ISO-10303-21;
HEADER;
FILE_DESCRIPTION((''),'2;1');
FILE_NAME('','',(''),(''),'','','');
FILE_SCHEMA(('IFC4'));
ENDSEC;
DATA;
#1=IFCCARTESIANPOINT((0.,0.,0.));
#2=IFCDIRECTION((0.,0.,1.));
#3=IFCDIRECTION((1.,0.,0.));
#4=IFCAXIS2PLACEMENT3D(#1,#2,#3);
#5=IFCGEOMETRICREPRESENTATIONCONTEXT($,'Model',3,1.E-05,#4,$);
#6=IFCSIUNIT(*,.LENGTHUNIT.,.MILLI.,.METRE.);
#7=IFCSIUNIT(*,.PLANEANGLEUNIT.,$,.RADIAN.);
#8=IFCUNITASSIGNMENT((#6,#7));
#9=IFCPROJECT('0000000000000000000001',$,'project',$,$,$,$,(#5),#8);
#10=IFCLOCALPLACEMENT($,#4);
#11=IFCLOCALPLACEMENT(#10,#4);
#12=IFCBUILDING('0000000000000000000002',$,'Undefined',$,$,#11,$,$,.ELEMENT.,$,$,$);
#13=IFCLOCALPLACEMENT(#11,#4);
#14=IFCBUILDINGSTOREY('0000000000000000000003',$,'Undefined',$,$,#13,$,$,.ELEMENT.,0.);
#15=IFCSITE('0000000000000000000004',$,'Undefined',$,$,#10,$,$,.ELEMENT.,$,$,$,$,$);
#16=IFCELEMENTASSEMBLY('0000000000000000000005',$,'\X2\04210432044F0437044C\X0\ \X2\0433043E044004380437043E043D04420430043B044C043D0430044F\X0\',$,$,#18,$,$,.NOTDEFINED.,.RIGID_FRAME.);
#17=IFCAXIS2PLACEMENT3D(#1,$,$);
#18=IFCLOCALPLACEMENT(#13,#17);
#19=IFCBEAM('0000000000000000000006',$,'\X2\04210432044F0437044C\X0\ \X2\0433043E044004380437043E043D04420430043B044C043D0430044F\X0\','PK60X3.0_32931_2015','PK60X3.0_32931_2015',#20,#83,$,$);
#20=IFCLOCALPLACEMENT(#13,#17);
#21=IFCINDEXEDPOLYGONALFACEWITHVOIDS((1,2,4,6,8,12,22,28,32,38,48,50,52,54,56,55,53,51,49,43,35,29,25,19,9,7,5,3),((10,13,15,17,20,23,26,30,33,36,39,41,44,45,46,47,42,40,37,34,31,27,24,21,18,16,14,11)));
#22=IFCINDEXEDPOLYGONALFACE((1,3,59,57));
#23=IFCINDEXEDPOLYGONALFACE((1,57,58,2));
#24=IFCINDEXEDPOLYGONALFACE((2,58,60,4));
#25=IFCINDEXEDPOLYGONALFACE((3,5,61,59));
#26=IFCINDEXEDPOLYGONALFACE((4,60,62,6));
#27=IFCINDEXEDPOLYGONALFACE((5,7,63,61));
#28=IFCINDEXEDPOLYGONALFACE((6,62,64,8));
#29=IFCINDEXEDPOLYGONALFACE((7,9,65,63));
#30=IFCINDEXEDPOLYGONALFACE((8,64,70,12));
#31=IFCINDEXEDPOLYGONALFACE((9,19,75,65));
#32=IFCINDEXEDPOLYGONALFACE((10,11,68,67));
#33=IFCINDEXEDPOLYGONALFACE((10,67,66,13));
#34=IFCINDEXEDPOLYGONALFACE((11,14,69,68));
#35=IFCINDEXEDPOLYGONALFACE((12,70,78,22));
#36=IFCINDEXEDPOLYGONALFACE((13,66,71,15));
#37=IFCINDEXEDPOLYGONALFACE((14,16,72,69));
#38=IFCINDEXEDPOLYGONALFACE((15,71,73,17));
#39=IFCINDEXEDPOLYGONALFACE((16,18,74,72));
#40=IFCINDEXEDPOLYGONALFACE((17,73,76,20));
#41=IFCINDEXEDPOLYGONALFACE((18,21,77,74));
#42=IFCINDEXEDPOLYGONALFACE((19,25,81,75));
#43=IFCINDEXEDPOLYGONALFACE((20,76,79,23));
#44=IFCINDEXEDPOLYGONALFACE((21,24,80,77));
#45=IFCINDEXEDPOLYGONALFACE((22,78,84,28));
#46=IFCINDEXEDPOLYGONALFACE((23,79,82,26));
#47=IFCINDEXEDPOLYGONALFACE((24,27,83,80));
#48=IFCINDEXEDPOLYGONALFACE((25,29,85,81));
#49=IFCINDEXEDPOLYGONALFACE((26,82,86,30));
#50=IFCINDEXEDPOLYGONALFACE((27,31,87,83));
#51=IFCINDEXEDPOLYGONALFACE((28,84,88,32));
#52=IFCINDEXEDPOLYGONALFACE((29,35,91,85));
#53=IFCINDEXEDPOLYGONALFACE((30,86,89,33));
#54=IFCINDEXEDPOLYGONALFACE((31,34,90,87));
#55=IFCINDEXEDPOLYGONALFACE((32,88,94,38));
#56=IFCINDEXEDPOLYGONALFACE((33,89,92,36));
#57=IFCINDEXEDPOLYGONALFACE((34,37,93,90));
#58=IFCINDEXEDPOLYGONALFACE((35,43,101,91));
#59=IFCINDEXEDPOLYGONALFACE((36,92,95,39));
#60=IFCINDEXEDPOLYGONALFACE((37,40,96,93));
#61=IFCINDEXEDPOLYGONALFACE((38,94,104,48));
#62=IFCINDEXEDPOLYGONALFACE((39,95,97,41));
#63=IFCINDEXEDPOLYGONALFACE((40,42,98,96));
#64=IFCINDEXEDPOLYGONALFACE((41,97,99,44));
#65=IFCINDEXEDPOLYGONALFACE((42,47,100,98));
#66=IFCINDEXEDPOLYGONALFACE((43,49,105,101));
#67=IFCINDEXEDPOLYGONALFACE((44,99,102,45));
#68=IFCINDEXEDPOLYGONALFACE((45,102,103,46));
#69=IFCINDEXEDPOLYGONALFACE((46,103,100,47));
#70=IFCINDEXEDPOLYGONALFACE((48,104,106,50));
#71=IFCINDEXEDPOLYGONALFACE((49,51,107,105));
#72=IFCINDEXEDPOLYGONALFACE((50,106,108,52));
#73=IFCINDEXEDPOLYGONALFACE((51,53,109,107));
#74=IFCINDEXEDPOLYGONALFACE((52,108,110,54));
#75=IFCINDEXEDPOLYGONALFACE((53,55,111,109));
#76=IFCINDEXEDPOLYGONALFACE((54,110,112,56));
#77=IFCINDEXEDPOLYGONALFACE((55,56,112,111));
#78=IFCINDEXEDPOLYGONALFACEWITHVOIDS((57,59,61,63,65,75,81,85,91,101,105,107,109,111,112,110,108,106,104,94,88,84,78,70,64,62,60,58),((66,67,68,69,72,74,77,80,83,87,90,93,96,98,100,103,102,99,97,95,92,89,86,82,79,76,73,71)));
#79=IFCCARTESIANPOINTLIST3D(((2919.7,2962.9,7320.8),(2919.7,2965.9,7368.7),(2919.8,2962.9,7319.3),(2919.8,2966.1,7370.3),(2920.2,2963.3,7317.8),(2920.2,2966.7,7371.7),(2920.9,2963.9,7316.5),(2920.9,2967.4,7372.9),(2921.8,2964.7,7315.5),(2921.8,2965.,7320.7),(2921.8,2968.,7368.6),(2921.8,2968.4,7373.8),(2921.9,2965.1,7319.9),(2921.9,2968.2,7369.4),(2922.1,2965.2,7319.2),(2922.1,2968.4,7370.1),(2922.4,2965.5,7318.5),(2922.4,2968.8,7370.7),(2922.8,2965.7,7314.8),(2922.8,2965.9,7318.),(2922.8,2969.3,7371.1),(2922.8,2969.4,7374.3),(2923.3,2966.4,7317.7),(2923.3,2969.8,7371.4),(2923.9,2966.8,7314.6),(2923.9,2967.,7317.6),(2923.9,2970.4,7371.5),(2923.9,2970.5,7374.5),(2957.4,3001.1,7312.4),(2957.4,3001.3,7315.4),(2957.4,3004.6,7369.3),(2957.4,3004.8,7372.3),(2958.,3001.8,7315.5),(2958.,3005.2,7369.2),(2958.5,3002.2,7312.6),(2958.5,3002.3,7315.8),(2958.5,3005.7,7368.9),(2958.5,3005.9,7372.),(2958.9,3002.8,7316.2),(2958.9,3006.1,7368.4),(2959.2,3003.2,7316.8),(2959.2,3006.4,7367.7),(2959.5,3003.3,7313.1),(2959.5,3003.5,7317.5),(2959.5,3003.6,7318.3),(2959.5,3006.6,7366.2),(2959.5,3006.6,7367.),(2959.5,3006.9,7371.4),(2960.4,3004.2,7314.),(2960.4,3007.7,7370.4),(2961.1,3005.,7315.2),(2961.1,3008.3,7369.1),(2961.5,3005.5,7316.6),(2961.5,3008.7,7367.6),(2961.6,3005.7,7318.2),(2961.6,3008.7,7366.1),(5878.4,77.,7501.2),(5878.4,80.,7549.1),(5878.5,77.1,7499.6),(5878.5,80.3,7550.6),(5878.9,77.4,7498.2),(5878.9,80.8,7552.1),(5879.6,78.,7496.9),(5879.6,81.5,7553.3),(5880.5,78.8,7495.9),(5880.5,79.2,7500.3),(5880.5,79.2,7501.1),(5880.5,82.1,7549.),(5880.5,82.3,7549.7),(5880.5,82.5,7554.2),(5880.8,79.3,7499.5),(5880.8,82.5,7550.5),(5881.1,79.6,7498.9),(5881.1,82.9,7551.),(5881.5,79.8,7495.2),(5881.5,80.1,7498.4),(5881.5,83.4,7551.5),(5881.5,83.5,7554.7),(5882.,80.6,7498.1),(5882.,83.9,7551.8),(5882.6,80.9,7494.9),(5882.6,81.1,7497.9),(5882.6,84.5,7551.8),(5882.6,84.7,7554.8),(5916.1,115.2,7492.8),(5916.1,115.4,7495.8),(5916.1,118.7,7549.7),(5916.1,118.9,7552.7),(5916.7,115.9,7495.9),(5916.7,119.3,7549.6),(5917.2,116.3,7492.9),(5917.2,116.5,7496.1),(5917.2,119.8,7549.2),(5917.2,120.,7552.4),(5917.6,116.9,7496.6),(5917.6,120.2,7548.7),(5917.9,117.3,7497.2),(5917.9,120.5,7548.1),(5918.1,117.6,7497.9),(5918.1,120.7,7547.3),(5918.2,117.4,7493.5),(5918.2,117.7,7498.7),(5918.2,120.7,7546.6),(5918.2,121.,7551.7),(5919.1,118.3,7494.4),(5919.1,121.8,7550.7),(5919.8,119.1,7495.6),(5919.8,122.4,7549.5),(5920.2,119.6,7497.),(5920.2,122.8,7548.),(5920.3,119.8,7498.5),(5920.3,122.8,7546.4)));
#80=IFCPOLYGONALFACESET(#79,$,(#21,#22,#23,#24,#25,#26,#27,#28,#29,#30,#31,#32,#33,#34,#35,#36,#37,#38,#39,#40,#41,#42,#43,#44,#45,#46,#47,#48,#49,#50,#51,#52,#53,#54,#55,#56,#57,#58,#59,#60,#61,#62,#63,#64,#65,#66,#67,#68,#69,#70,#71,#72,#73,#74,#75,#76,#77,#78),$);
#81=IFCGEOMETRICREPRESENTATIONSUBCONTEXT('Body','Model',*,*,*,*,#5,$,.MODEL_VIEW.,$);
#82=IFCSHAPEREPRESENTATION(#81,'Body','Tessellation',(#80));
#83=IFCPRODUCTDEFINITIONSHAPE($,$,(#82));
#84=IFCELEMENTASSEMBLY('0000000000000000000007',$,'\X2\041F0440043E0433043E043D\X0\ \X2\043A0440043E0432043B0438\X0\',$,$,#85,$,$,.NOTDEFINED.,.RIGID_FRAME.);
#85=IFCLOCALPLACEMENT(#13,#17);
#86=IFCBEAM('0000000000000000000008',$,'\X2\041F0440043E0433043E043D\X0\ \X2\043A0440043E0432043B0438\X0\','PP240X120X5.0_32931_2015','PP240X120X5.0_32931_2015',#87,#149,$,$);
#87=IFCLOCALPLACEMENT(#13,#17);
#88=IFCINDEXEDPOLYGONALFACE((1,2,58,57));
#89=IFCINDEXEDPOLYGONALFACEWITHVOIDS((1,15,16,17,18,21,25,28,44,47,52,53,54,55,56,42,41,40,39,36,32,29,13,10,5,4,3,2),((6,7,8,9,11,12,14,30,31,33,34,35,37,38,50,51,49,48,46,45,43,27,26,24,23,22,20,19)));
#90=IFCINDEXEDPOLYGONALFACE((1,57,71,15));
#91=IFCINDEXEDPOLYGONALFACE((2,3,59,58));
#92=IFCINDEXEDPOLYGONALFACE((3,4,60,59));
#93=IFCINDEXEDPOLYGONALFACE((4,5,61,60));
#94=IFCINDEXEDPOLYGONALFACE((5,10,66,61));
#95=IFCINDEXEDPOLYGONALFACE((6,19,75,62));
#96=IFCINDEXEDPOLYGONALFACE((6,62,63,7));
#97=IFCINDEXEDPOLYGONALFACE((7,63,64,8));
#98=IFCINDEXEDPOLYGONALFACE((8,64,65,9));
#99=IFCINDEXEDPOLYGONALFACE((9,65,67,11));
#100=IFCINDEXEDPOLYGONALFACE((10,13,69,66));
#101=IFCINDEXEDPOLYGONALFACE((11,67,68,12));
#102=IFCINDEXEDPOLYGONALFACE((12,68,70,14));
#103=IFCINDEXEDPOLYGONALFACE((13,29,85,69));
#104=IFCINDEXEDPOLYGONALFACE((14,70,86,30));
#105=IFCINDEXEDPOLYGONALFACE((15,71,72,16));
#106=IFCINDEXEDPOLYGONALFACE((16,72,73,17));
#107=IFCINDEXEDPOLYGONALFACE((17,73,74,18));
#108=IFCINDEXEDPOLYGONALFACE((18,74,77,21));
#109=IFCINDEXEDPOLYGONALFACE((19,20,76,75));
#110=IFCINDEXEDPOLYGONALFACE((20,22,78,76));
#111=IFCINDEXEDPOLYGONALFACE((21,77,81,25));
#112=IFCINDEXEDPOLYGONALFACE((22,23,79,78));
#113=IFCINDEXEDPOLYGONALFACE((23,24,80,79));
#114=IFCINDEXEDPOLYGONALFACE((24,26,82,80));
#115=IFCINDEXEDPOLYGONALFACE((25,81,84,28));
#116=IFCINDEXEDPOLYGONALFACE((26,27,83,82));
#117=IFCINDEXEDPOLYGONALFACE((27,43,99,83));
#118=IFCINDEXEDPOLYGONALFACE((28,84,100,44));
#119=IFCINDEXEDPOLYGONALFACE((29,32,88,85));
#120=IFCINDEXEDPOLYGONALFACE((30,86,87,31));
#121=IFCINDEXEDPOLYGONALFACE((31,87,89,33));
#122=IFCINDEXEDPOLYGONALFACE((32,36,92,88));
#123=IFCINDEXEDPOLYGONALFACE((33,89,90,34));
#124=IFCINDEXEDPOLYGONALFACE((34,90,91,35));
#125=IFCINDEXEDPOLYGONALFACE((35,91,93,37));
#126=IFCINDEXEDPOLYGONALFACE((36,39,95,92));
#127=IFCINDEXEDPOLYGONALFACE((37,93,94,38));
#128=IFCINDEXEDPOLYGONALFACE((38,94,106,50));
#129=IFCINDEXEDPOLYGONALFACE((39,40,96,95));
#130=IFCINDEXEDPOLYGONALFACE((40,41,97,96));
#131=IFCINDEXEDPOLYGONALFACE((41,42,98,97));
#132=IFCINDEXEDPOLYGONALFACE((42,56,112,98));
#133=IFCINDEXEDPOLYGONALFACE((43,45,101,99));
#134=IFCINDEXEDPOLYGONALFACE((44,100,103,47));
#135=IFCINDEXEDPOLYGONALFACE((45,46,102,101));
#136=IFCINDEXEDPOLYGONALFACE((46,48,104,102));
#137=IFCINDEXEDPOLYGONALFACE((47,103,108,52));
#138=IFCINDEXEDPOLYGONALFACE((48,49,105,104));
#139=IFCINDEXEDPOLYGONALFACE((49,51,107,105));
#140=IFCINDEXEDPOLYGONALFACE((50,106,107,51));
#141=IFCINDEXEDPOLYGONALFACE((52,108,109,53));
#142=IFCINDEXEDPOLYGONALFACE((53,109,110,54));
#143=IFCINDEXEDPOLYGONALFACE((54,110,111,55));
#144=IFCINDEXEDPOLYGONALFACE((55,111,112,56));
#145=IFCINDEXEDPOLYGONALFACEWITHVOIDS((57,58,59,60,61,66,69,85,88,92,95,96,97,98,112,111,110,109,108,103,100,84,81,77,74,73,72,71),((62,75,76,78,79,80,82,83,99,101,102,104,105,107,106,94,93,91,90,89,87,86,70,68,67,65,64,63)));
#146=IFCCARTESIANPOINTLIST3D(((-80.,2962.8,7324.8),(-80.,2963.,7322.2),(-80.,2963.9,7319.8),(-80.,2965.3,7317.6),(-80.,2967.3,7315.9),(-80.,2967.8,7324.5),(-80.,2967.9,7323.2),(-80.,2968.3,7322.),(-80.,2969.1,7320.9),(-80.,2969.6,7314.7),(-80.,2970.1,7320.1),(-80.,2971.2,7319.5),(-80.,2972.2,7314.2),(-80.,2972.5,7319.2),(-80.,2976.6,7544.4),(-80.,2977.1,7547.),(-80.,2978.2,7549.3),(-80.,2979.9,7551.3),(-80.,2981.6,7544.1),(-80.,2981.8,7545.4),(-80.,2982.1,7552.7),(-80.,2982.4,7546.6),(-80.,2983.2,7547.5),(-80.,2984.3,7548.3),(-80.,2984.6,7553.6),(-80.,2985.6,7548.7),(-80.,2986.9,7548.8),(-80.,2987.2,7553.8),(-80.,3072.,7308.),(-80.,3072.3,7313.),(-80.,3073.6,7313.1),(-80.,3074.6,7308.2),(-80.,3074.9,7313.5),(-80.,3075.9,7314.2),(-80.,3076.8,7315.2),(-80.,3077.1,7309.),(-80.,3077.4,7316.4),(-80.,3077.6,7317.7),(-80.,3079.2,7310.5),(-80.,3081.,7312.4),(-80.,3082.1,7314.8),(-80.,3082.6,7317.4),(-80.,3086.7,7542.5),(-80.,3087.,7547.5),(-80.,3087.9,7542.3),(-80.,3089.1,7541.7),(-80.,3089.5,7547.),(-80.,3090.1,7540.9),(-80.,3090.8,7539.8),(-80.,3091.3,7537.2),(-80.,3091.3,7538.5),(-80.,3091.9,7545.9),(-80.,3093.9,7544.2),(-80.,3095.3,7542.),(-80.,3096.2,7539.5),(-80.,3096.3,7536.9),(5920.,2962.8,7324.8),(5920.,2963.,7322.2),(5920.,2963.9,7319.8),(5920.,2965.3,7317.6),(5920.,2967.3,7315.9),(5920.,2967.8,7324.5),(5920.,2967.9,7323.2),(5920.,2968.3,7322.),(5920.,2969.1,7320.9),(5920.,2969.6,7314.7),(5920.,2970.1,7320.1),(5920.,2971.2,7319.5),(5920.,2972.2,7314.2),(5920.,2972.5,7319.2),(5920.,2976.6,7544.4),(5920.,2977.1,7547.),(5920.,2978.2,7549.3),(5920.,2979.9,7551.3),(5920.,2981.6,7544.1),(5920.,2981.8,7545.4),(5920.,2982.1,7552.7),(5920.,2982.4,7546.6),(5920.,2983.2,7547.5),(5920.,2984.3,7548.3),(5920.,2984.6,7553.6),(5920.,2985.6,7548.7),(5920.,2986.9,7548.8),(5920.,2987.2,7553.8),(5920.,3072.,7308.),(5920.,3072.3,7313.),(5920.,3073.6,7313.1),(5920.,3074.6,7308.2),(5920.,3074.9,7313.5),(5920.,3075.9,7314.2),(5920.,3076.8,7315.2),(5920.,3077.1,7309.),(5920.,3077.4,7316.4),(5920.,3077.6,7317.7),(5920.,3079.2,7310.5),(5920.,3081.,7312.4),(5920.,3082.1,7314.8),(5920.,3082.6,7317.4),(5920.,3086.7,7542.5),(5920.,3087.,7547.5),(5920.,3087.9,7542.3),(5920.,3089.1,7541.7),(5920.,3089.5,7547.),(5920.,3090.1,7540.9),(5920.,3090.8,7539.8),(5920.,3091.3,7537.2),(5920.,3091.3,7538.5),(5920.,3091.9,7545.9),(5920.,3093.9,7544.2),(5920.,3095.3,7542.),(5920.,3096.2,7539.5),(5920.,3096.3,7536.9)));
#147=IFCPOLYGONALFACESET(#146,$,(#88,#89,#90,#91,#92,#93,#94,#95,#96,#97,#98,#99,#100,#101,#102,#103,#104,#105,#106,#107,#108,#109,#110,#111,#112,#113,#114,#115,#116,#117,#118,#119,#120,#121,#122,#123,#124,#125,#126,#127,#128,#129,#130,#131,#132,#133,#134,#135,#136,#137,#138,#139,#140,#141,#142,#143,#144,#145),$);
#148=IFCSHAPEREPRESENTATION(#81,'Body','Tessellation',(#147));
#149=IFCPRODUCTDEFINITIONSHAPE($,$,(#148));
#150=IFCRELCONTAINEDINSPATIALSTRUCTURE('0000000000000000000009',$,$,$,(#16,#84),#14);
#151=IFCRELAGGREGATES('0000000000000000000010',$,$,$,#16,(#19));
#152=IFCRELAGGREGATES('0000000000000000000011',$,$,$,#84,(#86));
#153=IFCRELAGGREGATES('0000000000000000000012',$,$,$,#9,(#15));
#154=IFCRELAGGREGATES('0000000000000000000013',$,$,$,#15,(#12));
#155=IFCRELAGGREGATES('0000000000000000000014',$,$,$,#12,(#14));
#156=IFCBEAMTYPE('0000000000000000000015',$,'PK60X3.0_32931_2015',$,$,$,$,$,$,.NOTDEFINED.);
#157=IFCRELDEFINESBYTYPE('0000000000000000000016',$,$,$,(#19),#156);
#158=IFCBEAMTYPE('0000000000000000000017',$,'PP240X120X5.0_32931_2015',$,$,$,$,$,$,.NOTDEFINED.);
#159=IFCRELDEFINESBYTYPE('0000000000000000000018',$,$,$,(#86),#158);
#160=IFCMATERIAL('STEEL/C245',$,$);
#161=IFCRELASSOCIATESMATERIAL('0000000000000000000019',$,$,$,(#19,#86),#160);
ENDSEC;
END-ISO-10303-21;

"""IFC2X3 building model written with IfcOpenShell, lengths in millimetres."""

from ifc_helpers import new_model, si_unit, frame, origin_with_axes, origin_2d_with_axis, place, context, subcontext, project, spatial, hollow_rectangle, extrude, material, type_object, element, aggregate, save


model = new_model("IFC2X3")

# Units and contexts
model_context = context("Model", 3, precision=1e-05, world=origin_with_axes())
body_context = subcontext(model_context, "Body", "Model", "MODEL_VIEW")
ifc_project = project(units=[si_unit("LENGTHUNIT", "METRE", prefix="MILLI"), si_unit("PLANEANGLEUNIT", "RADIAN")], contexts=[model_context])

# Site, building, storey
site_placement = place(None, origin_with_axes())
site = spatial("IfcSite", under=ifc_project, at=site_placement, Name="Undefined", CompositionType="ELEMENT")
building_placement = place(site_placement, origin_with_axes())
building = spatial("IfcBuilding", under=site, at=building_placement, Name="Undefined", CompositionType="ELEMENT")
storey_placement = place(building_placement, origin_with_axes())
storey = spatial("IfcBuildingStorey", under=building, at=storey_placement, Name="Undefined", CompositionType="ELEMENT", Elevation=0.0)

# Shared definitions
ifc_material = material(Name="STEEL/C245")

# Element assemblies, beams
beam_type_1 = type_object("IfcBeamType", Name="PK60X3.0_32931_2015", PredefinedType="NOTDEFINED")
assembly_1_placement = place(storey_placement, origin_with_axes())
assembly_1 = element("IfcElementAssembly", 1, at=assembly_1_placement, inside=storey, Name="Связь горизонтальная", AssemblyPlace="NOTDEFINED", PredefinedType="RIGID_FRAME")
beam_1_placement = place(assembly_1_placement, frame((5899.3, 99.9, 7523.8), z_axis=(0.0, 0.062378, 0.998053), x_axis=(-0.715179, 0.69758, -0.043599)))
beam_1 = element("IfcBeam", 2, at=beam_1_placement, type_object=beam_type_1, material=ifc_material, Name="Связь горизонтальная", Description="PK60X3.0_32931_2015", ObjectType="PK60X3.0_32931_2015", context=body_context, shape_type="SweptSolid", body=[
    extrude(hollow_rectangle(XDim=60.0, YDim=60.0, WallThickness=3.0, InnerFilletRadius=3.0, OuterFilletRadius=6.0, at=origin_2d_with_axis()), frame((4137.0, 0.0, 0.0), z_axis=(-1.0, 0.0, 0.0), x_axis=(0.0, -1.0, 0.0)), (0.0, 0.0, 1.0), 4137.0),
])
aggregate(assembly_1, [beam_1])
assembly_2_placement = place(storey_placement, origin_with_axes())
assembly_2 = element("IfcElementAssembly", 3, at=assembly_2_placement, inside=storey, Name="Прогон кровли", AssemblyPlace="NOTDEFINED", PredefinedType="RIGID_FRAME")
beam_type_2 = type_object("IfcBeamType", Name="PP240X120X5.0_32931_2015", PredefinedType="NOTDEFINED")
beam_2_placement = place(assembly_2_placement, frame((5920.0, 3029.6, 7430.9), z_axis=(0.0, 0.062378, 0.998053), x_axis=(-1.0, 0.0, 0.0)))
beam_2 = element("IfcBeam", 4, at=beam_2_placement, type_object=beam_type_2, material=ifc_material, Name="Прогон кровли", Description="PP240X120X5.0_32931_2015", ObjectType="PP240X120X5.0_32931_2015", context=body_context, shape_type="SweptSolid", body=[
    extrude(hollow_rectangle(XDim=120.0, YDim=240.0, WallThickness=5.0, InnerFilletRadius=5.0, OuterFilletRadius=10.0, at=origin_2d_with_axis()), frame((6000.0, 0.0, 0.0), z_axis=(-1.0, 0.0, 0.0), x_axis=(0.0, -1.0, 0.0)), (0.0, 0.0, 1.0), 6000.0),
])
aggregate(assembly_2, [beam_2])

save(model, "model.ifc")
